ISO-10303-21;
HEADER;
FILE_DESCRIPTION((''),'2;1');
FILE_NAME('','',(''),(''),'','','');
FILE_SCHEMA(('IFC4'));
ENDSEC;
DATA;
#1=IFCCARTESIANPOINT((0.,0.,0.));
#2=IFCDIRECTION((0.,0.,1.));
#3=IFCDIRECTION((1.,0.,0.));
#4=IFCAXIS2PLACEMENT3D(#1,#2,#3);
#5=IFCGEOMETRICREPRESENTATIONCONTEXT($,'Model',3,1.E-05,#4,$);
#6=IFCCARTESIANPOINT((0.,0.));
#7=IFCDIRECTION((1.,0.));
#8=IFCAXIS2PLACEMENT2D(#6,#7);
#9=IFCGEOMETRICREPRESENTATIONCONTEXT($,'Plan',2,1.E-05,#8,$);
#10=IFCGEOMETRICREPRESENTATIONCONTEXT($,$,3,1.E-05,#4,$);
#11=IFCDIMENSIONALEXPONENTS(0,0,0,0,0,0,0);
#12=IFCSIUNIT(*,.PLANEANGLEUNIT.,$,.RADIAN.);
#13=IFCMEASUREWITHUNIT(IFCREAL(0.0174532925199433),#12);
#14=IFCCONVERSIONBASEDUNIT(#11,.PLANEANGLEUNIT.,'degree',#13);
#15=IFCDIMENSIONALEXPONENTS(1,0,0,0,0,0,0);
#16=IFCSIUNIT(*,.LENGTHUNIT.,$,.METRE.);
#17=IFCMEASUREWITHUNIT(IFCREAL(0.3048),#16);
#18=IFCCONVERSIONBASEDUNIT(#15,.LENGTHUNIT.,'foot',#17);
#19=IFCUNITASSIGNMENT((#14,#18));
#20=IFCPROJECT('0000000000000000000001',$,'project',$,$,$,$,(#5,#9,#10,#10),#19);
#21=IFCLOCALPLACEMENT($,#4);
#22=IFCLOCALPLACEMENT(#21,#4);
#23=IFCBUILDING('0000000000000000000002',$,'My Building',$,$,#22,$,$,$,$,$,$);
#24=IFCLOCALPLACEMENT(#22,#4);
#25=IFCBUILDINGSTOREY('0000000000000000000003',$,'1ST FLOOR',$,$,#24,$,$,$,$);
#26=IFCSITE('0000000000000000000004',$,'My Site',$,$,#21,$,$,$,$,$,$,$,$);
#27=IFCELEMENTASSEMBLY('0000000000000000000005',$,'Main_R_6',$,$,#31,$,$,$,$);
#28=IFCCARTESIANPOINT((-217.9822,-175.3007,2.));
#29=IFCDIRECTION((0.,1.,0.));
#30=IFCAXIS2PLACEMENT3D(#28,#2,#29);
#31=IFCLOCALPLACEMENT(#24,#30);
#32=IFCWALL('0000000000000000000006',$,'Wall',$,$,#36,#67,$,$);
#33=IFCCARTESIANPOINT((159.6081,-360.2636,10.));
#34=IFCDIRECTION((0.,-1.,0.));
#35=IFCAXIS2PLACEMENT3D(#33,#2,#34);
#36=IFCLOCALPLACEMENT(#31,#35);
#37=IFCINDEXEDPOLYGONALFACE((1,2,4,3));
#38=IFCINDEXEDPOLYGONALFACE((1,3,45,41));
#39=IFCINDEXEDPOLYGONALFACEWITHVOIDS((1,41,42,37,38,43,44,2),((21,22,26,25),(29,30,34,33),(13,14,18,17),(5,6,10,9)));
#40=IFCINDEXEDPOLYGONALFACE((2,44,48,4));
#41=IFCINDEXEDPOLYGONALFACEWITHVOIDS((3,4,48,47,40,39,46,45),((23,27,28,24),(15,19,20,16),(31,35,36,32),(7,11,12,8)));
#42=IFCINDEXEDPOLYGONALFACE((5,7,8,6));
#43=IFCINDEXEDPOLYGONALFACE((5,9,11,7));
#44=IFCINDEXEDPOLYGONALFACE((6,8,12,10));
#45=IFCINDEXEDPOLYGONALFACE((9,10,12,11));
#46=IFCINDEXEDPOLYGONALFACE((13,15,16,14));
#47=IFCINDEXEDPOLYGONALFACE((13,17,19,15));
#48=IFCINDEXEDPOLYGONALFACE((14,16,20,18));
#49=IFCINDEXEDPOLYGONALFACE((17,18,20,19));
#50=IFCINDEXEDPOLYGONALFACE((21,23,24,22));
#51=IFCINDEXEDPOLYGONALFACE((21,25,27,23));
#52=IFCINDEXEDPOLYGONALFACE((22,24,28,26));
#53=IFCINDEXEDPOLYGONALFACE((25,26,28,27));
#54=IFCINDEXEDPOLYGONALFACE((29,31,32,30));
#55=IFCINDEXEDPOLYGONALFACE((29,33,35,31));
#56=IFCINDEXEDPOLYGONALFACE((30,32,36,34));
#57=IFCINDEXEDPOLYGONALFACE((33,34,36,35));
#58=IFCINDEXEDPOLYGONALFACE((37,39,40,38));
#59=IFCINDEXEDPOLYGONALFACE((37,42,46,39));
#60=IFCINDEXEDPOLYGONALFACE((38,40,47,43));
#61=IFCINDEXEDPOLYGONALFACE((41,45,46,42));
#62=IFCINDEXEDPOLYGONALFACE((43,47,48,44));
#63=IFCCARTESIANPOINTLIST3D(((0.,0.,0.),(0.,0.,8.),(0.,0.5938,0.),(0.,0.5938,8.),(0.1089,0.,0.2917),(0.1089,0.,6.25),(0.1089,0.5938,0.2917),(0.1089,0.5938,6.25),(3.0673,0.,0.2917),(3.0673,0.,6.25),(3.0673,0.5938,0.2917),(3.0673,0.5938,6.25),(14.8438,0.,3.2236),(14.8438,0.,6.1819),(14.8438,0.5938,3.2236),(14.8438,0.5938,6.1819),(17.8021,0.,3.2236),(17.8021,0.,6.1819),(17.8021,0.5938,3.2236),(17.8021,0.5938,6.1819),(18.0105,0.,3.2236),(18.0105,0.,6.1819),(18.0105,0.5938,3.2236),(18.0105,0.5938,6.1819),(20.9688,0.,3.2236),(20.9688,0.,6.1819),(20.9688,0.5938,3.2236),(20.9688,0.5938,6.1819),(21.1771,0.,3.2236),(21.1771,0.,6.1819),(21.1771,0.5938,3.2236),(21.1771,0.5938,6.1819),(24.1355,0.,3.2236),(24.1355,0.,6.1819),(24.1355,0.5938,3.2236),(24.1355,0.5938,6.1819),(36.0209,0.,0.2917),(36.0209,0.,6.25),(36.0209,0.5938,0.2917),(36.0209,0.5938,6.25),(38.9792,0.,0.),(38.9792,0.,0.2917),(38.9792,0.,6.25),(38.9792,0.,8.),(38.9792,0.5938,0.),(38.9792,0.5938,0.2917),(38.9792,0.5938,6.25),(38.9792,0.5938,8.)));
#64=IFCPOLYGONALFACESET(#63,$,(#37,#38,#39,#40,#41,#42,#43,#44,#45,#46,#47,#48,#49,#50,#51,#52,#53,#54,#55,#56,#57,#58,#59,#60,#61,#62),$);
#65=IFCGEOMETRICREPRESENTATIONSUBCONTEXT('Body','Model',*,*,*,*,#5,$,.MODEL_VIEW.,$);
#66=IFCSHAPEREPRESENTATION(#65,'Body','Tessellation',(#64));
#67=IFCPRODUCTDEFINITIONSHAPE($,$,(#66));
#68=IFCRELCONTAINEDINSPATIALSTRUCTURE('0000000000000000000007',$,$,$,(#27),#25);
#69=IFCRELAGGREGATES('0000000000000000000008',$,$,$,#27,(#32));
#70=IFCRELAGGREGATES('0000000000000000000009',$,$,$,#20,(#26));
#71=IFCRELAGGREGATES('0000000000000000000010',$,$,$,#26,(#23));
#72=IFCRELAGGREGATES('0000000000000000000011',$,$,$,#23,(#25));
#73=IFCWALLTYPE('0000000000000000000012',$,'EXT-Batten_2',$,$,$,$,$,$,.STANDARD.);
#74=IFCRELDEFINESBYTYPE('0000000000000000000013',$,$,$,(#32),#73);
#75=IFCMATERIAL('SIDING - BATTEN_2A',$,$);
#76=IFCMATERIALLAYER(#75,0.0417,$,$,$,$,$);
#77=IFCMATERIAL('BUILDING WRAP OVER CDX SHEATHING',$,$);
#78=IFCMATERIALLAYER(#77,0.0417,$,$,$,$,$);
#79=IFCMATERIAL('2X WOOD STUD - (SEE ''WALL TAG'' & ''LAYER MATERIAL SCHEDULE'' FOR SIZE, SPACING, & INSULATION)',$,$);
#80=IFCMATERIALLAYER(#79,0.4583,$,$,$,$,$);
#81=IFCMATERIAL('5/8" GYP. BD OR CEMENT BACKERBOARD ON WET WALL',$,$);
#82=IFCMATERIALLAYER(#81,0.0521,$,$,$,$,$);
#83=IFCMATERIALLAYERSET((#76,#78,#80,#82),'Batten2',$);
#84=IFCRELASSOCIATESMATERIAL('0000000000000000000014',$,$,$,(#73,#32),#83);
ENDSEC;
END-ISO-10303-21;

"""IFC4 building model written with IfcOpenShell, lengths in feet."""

from ifc_helpers import new_model, entity, si_unit, converted_unit, frame, origin_with_axes, origin_2d_with_axis, place, context, subcontext, project, spatial, line, indexed_curve, outline, extrude, source, transform, mapped, material, layer, layer_set, layer_usage, type_object, element, aggregate, save


model = new_model("IFC4")

# Units and contexts
model_context = context("Model", 3, precision=1e-05, world=origin_with_axes())
plan_context = context("Plan", 2, precision=1e-05, world=origin_2d_with_axis())
context_of_model = context(None, 3, precision=1e-05, world=origin_with_axes())
body_context = subcontext(model_context, "Body", "Model", "MODEL_VIEW")
ifc_project = project(units=[converted_unit("PLANEANGLEUNIT", "degree", entity("IfcReal", 0.0174532925199433), si_unit("PLANEANGLEUNIT", "RADIAN"), dimensions=[0, 0, 0, 0, 0, 0, 0]), converted_unit("LENGTHUNIT", "foot", entity("IfcReal", 0.3048), si_unit("LENGTHUNIT", "METRE"), dimensions=[1, 0, 0, 0, 0, 0, 0])], contexts=[model_context, plan_context, context_of_model, context_of_model])

# Site, building, storey
site_placement = place(None, origin_with_axes())
site = spatial("IfcSite", under=ifc_project, at=site_placement, Name="My Site")
building_placement = place(site_placement, origin_with_axes())
building = spatial("IfcBuilding", under=site, at=building_placement, Name="My Building")
storey_placement = place(building_placement, origin_with_axes())
storey = spatial("IfcBuildingStorey", under=building, at=storey_placement, Name="1ST FLOOR")

# Element assembly, wall, openings
assembly_placement = place(storey_placement, frame((-217.9822, -175.3007, 2.0), z_axis=(0.0, 0.0, 1.0), x_axis=(0.0, 1.0, 0.0)))
assembly = element("IfcElementAssembly", 1, at=assembly_placement, inside=storey, Name="Main_R_6")
ifc_material_1 = material(Name="BUILDING WRAP OVER CDX SHEATHING")
ifc_material_2 = material(Name="2X WOOD STUD - (SEE 'WALL TAG' & 'LAYER MATERIAL SCHEDULE' FOR SIZE, SPACING, & INSULATION)")
ifc_material_3 = material(Name="5/8\" GYP. BD OR CEMENT BACKERBOARD ON WET WALL")
shared_shape_1 = source(origin_with_axes(), body_context, "Body", "SweptSolid", [
    extrude(outline(indexed_curve([(0.0, 0.0), (2.9583, 0.0), (2.9583, 5.9583), (0.0, 5.9583)], segments=[line(1, 2, 3, 4, 1)])), frame((0.0, -1.9685, 0.0), z_axis=(0.0, -1.0, 0.0), x_axis=(1.0, 0.0, 0.0)), (0.0, 0.0, -1.0), 3.937),
])
ifc_material_4 = material(Name="SIDING - BATTEN_2A")
ifc_layer_1 = layer(ifc_material_4, 0.0417)
ifc_layer_2 = layer(ifc_material_1, 0.0417)
ifc_layer_3 = layer(ifc_material_2, 0.4583)
ifc_layer_4 = layer(ifc_material_3, 0.0521)
ifc_layer_set_1 = layer_set([ifc_layer_1, ifc_layer_2, ifc_layer_3, ifc_layer_4], Name="Batten2")
ifc_layer_usage_1 = layer_usage(ifc_layer_set_1, "AXIS2", "POSITIVE", 0.0)
wall_type_1 = type_object("IfcWallType", Name="EXT-Batten_2", PredefinedType="STANDARD", material=ifc_layer_set_1)
wall_1_placement = place(assembly_placement, frame((159.6081, -360.2636, 10.0), z_axis=(0.0, 0.0, 1.0), x_axis=(0.0, -1.0, 0.0)))
wall_1 = element("IfcWall", 2, at=wall_1_placement, type_object=wall_type_1, material=ifc_layer_usage_1, Name="Wall", context=body_context, shape_type="SweptSolid", body=[
    extrude(outline(indexed_curve([(0.0, 0.0), (0.0, 0.5938), (38.9792, 0.5938), (38.9792, 0.0), (0.0, 0.0)], self_intersect=False)), origin_with_axes(), (0.0, 0.0, 1.0), 8.0),
])
opening_1_placement = place(wall_1_placement, frame((0.1089, 0.0, 0.2917), z_axis=(0.0, 0.0, 1.0), x_axis=(1.0, 0.0, 0.0)))
element("IfcOpeningElement", 3, at=opening_1_placement, cuts=wall_1, PredefinedType="OPENING", context=body_context, shape_type="MappedRepresentation", body=[
    mapped(shared_shape_1, transform((0.0, 0.0, 0.0), x_axis=(1.0, 0.0, 0.0), y_axis=(0.0, 1.0, 0.0), z_axis=(0.0, 0.0, 1.0), scale=1.0)),
])
opening_2_placement = place(wall_1_placement, frame((36.0209, 0.0, 0.2917), z_axis=(0.0, 0.0, 1.0), x_axis=(1.0, 0.0, 0.0)))
element("IfcOpeningElement", 4, at=opening_2_placement, cuts=wall_1, PredefinedType="OPENING", context=body_context, shape_type="MappedRepresentation", body=[
    mapped(shared_shape_1, transform((0.0, 0.0, 0.0), x_axis=(1.0, 0.0, 0.0), y_axis=(0.0, 1.0, 0.0), z_axis=(0.0, 0.0, 1.0), scale=1.0)),
])
shared_shape_2 = source(origin_with_axes(), body_context, "Body", "SweptSolid", [
    extrude(outline(indexed_curve([(0.0, 0.0), (2.9583, 0.0), (2.9583, 2.9583), (0.0, 2.9583)], segments=[line(1, 2, 3, 4, 1)])), frame((0.0, -1.9685, 0.0), z_axis=(0.0, -1.0, 0.0), x_axis=(1.0, 0.0, 0.0)), (0.0, 0.0, -1.0), 3.937),
])
opening_3_placement = place(wall_1_placement, frame((14.8438, 0.0, 3.2236), z_axis=(0.0, 0.0, 1.0), x_axis=(1.0, 0.0, 0.0)))
element("IfcOpeningElement", 5, at=opening_3_placement, cuts=wall_1, PredefinedType="OPENING", context=body_context, shape_type="MappedRepresentation", body=[
    mapped(shared_shape_2, transform((0.0, 0.0, 0.0), x_axis=(1.0, 0.0, 0.0), y_axis=(0.0, 1.0, 0.0), z_axis=(0.0, 0.0, 1.0), scale=1.0)),
])
opening_4_placement = place(wall_1_placement, frame((21.1771, 0.0, 3.2236), z_axis=(0.0, 0.0, 1.0), x_axis=(1.0, 0.0, 0.0)))
element("IfcOpeningElement", 6, at=opening_4_placement, cuts=wall_1, PredefinedType="OPENING", context=body_context, shape_type="MappedRepresentation", body=[
    mapped(shared_shape_2, transform((0.0, 0.0, 0.0), x_axis=(1.0, 0.0, 0.0), y_axis=(0.0, 1.0, 0.0), z_axis=(0.0, 0.0, 1.0), scale=1.0)),
])
opening_5_placement = place(wall_1_placement, frame((18.0105, 0.0, 3.2236), z_axis=(0.0, 0.0, 1.0), x_axis=(1.0, 0.0, 0.0)))
element("IfcOpeningElement", 7, at=opening_5_placement, cuts=wall_1, PredefinedType="OPENING", context=body_context, shape_type="MappedRepresentation", body=[
    mapped(shared_shape_2, transform((0.0, 0.0, 0.0), x_axis=(1.0, 0.0, 0.0), y_axis=(0.0, 1.0, 0.0), z_axis=(0.0, 0.0, 1.0), scale=1.0)),
])
aggregate(assembly, [wall_1])

save(model, "model.ifc")
